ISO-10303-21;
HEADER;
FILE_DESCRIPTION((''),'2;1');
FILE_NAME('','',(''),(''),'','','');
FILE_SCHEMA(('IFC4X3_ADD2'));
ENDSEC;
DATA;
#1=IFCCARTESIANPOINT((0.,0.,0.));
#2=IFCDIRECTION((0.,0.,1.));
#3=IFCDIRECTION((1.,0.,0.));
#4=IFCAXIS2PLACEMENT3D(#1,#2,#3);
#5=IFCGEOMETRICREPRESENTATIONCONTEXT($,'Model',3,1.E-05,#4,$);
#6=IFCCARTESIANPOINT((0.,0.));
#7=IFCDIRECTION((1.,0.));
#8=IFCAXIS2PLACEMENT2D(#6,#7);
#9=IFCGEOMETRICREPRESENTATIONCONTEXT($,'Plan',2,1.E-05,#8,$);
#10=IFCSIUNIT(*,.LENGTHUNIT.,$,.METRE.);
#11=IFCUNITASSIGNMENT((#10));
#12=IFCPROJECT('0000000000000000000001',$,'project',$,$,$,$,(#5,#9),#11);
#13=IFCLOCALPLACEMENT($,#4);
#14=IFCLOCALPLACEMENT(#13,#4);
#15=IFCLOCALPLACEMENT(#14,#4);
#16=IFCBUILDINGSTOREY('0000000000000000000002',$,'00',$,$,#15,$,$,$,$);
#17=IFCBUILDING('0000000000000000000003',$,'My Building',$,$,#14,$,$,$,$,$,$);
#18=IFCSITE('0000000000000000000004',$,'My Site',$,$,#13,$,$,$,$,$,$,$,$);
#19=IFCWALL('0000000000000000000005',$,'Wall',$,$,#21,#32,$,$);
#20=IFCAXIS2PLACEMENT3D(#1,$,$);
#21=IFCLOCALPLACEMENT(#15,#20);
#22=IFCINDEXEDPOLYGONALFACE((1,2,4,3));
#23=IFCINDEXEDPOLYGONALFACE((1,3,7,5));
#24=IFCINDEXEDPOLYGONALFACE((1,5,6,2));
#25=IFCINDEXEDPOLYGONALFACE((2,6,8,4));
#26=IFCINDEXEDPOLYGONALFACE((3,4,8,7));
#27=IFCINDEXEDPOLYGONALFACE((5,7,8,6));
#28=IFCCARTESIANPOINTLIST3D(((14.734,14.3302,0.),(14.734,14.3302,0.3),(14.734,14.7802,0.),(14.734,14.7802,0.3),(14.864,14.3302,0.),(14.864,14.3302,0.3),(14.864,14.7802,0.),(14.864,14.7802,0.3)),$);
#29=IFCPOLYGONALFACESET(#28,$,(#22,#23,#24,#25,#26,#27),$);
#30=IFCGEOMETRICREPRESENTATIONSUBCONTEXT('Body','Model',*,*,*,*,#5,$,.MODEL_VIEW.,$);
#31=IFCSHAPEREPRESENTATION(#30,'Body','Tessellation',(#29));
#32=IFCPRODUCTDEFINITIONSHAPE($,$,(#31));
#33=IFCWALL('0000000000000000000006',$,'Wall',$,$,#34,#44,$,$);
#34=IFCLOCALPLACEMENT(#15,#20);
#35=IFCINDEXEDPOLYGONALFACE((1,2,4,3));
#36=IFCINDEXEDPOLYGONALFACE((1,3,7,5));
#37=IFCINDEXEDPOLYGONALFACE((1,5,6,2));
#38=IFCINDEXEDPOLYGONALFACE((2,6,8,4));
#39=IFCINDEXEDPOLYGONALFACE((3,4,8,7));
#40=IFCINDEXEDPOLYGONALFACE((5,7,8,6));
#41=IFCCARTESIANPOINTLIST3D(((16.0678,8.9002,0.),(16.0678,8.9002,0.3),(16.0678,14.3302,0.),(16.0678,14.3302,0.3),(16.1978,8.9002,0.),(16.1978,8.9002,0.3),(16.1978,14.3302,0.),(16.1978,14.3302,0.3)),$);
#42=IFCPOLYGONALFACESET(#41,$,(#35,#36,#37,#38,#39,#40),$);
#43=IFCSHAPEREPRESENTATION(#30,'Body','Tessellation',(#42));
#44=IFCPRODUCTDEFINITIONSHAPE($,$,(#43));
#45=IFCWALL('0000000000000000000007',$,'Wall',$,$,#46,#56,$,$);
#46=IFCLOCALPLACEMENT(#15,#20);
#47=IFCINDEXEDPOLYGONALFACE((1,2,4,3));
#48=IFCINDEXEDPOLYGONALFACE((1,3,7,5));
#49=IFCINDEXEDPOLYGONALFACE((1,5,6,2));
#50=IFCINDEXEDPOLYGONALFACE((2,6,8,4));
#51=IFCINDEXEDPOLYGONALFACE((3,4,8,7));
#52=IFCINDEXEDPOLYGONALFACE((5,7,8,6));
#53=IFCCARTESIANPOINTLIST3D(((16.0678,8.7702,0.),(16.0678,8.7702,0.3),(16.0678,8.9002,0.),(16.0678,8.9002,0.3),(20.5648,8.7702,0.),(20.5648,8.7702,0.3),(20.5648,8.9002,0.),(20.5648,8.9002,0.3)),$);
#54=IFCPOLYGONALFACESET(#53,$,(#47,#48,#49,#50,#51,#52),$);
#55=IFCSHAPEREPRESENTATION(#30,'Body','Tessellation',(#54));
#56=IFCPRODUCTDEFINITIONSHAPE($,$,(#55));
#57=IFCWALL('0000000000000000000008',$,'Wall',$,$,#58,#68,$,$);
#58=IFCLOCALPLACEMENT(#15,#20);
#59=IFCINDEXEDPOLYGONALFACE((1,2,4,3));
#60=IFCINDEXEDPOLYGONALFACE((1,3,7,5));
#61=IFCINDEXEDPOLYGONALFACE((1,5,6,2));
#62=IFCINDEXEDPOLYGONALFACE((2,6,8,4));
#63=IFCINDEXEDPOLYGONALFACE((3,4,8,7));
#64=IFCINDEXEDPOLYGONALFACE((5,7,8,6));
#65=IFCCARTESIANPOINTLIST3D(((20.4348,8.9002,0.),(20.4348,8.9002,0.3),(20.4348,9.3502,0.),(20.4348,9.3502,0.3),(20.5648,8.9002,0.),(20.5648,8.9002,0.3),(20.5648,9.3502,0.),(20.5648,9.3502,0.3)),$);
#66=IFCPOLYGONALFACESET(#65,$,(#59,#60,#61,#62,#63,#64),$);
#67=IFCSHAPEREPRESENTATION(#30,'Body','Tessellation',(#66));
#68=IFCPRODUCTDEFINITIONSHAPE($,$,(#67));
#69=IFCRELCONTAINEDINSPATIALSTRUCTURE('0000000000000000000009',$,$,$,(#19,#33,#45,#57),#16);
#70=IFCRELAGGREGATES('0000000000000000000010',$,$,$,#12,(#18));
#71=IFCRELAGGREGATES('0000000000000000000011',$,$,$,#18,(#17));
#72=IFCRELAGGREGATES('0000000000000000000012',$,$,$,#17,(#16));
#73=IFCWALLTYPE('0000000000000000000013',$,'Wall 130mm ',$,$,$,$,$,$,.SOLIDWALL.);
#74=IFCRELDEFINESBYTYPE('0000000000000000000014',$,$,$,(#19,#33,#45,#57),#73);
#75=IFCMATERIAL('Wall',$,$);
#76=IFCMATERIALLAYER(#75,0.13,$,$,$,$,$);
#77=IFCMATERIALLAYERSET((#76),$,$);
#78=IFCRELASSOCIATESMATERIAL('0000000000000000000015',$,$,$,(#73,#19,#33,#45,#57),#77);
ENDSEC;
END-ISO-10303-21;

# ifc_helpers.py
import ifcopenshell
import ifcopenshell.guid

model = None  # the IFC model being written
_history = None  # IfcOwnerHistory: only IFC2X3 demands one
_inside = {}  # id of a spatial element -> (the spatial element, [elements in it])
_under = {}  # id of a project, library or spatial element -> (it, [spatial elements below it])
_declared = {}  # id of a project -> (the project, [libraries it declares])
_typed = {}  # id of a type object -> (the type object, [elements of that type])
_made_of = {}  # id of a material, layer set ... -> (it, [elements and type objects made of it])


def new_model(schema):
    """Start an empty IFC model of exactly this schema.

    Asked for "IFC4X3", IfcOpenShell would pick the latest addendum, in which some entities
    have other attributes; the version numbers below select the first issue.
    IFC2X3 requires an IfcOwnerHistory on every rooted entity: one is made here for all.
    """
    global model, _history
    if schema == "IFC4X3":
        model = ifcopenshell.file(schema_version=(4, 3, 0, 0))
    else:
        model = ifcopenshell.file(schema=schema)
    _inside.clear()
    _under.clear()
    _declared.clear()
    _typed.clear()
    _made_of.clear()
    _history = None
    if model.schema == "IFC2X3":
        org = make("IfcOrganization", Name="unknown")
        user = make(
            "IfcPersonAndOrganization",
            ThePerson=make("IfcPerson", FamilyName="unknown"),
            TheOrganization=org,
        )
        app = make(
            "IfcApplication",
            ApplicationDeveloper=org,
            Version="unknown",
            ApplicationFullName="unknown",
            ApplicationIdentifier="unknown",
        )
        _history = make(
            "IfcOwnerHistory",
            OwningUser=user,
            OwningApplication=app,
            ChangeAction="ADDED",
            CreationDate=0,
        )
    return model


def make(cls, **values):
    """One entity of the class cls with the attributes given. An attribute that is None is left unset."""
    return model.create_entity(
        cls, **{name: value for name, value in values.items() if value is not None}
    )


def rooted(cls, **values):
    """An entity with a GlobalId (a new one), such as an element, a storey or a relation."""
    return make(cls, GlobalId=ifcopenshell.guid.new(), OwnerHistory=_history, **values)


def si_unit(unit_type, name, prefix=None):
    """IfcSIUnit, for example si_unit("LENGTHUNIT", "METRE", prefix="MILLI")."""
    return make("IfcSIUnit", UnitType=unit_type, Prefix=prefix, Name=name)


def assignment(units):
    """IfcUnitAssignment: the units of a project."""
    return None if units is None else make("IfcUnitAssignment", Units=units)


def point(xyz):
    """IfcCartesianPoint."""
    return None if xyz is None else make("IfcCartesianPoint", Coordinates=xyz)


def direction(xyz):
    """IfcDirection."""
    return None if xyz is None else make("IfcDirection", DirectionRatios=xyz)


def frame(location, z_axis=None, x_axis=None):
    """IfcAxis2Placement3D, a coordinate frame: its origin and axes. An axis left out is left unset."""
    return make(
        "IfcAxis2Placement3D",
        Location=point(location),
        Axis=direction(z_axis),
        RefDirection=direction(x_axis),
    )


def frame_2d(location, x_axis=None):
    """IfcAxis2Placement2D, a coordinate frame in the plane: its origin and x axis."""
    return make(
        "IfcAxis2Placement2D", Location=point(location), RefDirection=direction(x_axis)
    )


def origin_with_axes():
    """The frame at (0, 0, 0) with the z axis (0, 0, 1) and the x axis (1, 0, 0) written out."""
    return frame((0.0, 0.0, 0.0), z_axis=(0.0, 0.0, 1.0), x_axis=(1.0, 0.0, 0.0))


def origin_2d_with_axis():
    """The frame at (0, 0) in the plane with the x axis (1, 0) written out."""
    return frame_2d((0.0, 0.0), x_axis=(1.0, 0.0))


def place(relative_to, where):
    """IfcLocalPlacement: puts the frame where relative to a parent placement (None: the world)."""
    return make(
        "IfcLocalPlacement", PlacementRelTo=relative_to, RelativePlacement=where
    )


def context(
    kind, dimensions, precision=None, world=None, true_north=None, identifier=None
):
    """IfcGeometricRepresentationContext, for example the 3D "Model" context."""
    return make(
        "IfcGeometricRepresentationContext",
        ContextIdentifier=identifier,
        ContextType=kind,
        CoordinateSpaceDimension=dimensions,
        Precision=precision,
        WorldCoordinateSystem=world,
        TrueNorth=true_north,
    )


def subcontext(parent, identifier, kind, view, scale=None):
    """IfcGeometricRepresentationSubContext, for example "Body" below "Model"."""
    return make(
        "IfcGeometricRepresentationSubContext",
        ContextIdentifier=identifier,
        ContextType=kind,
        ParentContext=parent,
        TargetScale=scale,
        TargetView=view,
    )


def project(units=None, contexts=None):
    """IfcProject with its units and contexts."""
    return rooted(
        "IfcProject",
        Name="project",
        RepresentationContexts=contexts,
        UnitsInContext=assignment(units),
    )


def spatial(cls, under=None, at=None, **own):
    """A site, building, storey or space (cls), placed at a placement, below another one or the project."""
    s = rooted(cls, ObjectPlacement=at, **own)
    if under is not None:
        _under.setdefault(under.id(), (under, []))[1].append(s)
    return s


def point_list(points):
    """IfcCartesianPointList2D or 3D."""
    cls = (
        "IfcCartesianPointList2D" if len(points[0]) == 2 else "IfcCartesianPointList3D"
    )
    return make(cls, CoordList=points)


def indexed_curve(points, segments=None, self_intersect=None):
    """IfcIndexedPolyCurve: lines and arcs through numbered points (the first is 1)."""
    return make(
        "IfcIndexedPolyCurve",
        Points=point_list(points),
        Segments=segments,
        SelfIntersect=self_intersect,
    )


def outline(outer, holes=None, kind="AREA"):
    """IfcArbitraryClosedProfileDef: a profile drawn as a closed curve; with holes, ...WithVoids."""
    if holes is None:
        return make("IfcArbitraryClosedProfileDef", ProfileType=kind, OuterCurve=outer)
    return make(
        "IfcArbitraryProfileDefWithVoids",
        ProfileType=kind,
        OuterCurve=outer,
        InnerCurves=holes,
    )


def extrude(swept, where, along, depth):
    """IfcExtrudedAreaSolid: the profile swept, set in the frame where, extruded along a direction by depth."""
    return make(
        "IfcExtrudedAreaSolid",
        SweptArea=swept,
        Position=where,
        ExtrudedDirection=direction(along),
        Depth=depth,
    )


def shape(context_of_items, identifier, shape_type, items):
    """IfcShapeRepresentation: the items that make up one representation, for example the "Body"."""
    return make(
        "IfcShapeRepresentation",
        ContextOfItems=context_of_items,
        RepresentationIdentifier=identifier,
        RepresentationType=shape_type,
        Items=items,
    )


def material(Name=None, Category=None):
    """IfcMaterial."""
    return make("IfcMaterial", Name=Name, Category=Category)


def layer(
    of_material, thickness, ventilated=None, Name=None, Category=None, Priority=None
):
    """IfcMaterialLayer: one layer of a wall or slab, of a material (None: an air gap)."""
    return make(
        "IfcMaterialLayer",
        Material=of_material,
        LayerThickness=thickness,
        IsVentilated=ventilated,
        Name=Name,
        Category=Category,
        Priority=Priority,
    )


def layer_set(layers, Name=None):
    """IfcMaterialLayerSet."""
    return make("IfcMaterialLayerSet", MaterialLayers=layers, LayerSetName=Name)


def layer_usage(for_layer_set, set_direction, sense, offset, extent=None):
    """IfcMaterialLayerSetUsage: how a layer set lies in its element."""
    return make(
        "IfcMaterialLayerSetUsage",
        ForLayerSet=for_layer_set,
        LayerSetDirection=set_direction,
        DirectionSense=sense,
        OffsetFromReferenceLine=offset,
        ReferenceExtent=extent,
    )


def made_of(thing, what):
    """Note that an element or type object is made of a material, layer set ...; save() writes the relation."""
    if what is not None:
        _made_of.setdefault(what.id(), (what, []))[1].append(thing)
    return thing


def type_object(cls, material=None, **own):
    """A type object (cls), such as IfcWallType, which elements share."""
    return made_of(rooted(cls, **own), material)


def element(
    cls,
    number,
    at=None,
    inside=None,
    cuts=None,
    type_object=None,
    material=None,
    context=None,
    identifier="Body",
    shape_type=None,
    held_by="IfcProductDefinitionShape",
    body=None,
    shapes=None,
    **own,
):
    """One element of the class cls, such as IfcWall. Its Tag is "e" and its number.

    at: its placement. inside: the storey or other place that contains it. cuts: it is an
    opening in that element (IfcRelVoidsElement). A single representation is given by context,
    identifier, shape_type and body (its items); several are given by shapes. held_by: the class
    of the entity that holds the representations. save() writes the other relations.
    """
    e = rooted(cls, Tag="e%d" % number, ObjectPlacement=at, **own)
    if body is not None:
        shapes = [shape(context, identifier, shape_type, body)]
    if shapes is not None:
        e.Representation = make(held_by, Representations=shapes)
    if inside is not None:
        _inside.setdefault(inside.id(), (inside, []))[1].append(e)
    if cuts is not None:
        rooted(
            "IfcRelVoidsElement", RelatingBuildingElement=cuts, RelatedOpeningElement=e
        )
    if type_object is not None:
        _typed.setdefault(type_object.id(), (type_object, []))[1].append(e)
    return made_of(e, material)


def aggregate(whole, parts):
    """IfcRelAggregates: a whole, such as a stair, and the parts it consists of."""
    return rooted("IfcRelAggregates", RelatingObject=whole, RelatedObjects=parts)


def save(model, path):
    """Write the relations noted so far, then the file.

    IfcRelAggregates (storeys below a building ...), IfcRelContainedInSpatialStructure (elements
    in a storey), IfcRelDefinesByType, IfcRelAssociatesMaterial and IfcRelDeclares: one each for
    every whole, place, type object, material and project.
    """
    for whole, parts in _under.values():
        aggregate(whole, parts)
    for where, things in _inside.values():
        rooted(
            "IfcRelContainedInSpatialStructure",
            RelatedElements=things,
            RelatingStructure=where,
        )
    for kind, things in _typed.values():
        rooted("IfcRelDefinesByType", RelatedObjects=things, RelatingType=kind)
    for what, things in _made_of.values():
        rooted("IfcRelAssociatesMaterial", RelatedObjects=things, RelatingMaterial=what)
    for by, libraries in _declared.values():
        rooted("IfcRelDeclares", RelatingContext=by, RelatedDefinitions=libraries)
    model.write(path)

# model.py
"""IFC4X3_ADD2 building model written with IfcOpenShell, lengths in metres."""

from ifc_helpers import new_model, si_unit, frame, origin_with_axes, origin_2d_with_axis, place, context, subcontext, project, spatial, indexed_curve, outline, extrude, material, layer, layer_set, layer_usage, type_object, element, save


model = new_model("IFC4X3_ADD2")

# Units and contexts
model_context = context("Model", 3, precision=1e-05, world=origin_with_axes())
plan_context = context("Plan", 2, precision=1e-05, world=origin_2d_with_axis())
body_context = subcontext(model_context, "Body", "Model", "MODEL_VIEW")
ifc_project = project(units=[si_unit("LENGTHUNIT", "METRE")], contexts=[model_context, plan_context])

# Site, building, storey
site_placement = place(None, origin_with_axes())
site = spatial("IfcSite", under=ifc_project, at=site_placement, Name="My Site")
building_placement = place(site_placement, origin_with_axes())
building = spatial("IfcBuilding", under=site, at=building_placement, Name="My Building")
storey_placement = place(building_placement, origin_with_axes())
storey = spatial("IfcBuildingStorey", under=building, at=storey_placement, Name="00")

# Walls
ifc_material_1 = material(Name="Wall")
ifc_layer_1 = layer(ifc_material_1, 0.13)
ifc_layer_set_1 = layer_set([ifc_layer_1])
wall_type_1 = type_object("IfcWallType", Name="Wall 130mm ", PredefinedType="SOLIDWALL", material=ifc_layer_set_1)
ifc_layer_usage_1 = layer_usage(ifc_layer_set_1, "AXIS2", "POSITIVE", 0.0)
wall_1_placement = place(storey_placement, frame((14.864, 14.3302, 0.0), z_axis=(0.0, 0.0, 1.0), x_axis=(0.0, 1.0, 0.0)))
element("IfcWall", 1, at=wall_1_placement, inside=storey, type_object=wall_type_1, material=ifc_layer_usage_1, Name="Wall", context=body_context, shape_type="SweptSolid", body=[
    extrude(outline(indexed_curve([(0.0, 0.0), (0.0, 0.13), (0.45, 0.13), (0.45, 0.0), (0.0, 0.0)], self_intersect=False)), origin_with_axes(), (0.0, 0.0, 1.0), 0.3),
])
ifc_layer_usage_2 = layer_usage(ifc_layer_set_1, "AXIS2", "POSITIVE", 0.0)
wall_2_placement = place(storey_placement, frame((16.1978, 8.9002, 0.0), z_axis=(0.0, 0.0, 1.0), x_axis=(0.0, 1.0, 0.0)))
element("IfcWall", 2, at=wall_2_placement, inside=storey, type_object=wall_type_1, material=ifc_layer_usage_2, Name="Wall", context=body_context, shape_type="SweptSolid", body=[
    extrude(outline(indexed_curve([(0.0, 0.0), (0.0, 0.13), (5.43, 0.13), (5.43, 0.0), (0.0, 0.0)], self_intersect=False)), origin_with_axes(), (0.0, 0.0, 1.0), 0.3),
])
ifc_layer_usage_3 = layer_usage(ifc_layer_set_1, "AXIS2", "POSITIVE", 0.0)
wall_3_placement = place(storey_placement, frame((16.0678, 8.7702, 0.0), z_axis=(0.0, 0.0, 1.0), x_axis=(1.0, 0.0, 0.0)))
element("IfcWall", 3, at=wall_3_placement, inside=storey, type_object=wall_type_1, material=ifc_layer_usage_3, Name="Wall", context=body_context, shape_type="SweptSolid", body=[
    extrude(outline(indexed_curve([(0.0, 0.0), (0.0, 0.13), (4.497, 0.13), (4.497, 0.0), (0.0, 0.0)], self_intersect=False)), origin_with_axes(), (0.0, 0.0, 1.0), 0.3),
])
ifc_layer_usage_4 = layer_usage(ifc_layer_set_1, "AXIS2", "POSITIVE", 0.0)
wall_4_placement = place(storey_placement, frame((20.5648, 8.9002, 0.0), z_axis=(0.0, 0.0, 1.0), x_axis=(0.0, 1.0, 0.0)))
element("IfcWall", 4, at=wall_4_placement, inside=storey, type_object=wall_type_1, material=ifc_layer_usage_4, Name="Wall", context=body_context, shape_type="SweptSolid", body=[
    extrude(outline(indexed_curve([(0.0, 0.0), (0.0, 0.13), (0.45, 0.13), (0.45, 0.0), (0.0, 0.0)], self_intersect=False)), origin_with_axes(), (0.0, 0.0, 1.0), 0.3),
])

save(model, "model.ifc")
